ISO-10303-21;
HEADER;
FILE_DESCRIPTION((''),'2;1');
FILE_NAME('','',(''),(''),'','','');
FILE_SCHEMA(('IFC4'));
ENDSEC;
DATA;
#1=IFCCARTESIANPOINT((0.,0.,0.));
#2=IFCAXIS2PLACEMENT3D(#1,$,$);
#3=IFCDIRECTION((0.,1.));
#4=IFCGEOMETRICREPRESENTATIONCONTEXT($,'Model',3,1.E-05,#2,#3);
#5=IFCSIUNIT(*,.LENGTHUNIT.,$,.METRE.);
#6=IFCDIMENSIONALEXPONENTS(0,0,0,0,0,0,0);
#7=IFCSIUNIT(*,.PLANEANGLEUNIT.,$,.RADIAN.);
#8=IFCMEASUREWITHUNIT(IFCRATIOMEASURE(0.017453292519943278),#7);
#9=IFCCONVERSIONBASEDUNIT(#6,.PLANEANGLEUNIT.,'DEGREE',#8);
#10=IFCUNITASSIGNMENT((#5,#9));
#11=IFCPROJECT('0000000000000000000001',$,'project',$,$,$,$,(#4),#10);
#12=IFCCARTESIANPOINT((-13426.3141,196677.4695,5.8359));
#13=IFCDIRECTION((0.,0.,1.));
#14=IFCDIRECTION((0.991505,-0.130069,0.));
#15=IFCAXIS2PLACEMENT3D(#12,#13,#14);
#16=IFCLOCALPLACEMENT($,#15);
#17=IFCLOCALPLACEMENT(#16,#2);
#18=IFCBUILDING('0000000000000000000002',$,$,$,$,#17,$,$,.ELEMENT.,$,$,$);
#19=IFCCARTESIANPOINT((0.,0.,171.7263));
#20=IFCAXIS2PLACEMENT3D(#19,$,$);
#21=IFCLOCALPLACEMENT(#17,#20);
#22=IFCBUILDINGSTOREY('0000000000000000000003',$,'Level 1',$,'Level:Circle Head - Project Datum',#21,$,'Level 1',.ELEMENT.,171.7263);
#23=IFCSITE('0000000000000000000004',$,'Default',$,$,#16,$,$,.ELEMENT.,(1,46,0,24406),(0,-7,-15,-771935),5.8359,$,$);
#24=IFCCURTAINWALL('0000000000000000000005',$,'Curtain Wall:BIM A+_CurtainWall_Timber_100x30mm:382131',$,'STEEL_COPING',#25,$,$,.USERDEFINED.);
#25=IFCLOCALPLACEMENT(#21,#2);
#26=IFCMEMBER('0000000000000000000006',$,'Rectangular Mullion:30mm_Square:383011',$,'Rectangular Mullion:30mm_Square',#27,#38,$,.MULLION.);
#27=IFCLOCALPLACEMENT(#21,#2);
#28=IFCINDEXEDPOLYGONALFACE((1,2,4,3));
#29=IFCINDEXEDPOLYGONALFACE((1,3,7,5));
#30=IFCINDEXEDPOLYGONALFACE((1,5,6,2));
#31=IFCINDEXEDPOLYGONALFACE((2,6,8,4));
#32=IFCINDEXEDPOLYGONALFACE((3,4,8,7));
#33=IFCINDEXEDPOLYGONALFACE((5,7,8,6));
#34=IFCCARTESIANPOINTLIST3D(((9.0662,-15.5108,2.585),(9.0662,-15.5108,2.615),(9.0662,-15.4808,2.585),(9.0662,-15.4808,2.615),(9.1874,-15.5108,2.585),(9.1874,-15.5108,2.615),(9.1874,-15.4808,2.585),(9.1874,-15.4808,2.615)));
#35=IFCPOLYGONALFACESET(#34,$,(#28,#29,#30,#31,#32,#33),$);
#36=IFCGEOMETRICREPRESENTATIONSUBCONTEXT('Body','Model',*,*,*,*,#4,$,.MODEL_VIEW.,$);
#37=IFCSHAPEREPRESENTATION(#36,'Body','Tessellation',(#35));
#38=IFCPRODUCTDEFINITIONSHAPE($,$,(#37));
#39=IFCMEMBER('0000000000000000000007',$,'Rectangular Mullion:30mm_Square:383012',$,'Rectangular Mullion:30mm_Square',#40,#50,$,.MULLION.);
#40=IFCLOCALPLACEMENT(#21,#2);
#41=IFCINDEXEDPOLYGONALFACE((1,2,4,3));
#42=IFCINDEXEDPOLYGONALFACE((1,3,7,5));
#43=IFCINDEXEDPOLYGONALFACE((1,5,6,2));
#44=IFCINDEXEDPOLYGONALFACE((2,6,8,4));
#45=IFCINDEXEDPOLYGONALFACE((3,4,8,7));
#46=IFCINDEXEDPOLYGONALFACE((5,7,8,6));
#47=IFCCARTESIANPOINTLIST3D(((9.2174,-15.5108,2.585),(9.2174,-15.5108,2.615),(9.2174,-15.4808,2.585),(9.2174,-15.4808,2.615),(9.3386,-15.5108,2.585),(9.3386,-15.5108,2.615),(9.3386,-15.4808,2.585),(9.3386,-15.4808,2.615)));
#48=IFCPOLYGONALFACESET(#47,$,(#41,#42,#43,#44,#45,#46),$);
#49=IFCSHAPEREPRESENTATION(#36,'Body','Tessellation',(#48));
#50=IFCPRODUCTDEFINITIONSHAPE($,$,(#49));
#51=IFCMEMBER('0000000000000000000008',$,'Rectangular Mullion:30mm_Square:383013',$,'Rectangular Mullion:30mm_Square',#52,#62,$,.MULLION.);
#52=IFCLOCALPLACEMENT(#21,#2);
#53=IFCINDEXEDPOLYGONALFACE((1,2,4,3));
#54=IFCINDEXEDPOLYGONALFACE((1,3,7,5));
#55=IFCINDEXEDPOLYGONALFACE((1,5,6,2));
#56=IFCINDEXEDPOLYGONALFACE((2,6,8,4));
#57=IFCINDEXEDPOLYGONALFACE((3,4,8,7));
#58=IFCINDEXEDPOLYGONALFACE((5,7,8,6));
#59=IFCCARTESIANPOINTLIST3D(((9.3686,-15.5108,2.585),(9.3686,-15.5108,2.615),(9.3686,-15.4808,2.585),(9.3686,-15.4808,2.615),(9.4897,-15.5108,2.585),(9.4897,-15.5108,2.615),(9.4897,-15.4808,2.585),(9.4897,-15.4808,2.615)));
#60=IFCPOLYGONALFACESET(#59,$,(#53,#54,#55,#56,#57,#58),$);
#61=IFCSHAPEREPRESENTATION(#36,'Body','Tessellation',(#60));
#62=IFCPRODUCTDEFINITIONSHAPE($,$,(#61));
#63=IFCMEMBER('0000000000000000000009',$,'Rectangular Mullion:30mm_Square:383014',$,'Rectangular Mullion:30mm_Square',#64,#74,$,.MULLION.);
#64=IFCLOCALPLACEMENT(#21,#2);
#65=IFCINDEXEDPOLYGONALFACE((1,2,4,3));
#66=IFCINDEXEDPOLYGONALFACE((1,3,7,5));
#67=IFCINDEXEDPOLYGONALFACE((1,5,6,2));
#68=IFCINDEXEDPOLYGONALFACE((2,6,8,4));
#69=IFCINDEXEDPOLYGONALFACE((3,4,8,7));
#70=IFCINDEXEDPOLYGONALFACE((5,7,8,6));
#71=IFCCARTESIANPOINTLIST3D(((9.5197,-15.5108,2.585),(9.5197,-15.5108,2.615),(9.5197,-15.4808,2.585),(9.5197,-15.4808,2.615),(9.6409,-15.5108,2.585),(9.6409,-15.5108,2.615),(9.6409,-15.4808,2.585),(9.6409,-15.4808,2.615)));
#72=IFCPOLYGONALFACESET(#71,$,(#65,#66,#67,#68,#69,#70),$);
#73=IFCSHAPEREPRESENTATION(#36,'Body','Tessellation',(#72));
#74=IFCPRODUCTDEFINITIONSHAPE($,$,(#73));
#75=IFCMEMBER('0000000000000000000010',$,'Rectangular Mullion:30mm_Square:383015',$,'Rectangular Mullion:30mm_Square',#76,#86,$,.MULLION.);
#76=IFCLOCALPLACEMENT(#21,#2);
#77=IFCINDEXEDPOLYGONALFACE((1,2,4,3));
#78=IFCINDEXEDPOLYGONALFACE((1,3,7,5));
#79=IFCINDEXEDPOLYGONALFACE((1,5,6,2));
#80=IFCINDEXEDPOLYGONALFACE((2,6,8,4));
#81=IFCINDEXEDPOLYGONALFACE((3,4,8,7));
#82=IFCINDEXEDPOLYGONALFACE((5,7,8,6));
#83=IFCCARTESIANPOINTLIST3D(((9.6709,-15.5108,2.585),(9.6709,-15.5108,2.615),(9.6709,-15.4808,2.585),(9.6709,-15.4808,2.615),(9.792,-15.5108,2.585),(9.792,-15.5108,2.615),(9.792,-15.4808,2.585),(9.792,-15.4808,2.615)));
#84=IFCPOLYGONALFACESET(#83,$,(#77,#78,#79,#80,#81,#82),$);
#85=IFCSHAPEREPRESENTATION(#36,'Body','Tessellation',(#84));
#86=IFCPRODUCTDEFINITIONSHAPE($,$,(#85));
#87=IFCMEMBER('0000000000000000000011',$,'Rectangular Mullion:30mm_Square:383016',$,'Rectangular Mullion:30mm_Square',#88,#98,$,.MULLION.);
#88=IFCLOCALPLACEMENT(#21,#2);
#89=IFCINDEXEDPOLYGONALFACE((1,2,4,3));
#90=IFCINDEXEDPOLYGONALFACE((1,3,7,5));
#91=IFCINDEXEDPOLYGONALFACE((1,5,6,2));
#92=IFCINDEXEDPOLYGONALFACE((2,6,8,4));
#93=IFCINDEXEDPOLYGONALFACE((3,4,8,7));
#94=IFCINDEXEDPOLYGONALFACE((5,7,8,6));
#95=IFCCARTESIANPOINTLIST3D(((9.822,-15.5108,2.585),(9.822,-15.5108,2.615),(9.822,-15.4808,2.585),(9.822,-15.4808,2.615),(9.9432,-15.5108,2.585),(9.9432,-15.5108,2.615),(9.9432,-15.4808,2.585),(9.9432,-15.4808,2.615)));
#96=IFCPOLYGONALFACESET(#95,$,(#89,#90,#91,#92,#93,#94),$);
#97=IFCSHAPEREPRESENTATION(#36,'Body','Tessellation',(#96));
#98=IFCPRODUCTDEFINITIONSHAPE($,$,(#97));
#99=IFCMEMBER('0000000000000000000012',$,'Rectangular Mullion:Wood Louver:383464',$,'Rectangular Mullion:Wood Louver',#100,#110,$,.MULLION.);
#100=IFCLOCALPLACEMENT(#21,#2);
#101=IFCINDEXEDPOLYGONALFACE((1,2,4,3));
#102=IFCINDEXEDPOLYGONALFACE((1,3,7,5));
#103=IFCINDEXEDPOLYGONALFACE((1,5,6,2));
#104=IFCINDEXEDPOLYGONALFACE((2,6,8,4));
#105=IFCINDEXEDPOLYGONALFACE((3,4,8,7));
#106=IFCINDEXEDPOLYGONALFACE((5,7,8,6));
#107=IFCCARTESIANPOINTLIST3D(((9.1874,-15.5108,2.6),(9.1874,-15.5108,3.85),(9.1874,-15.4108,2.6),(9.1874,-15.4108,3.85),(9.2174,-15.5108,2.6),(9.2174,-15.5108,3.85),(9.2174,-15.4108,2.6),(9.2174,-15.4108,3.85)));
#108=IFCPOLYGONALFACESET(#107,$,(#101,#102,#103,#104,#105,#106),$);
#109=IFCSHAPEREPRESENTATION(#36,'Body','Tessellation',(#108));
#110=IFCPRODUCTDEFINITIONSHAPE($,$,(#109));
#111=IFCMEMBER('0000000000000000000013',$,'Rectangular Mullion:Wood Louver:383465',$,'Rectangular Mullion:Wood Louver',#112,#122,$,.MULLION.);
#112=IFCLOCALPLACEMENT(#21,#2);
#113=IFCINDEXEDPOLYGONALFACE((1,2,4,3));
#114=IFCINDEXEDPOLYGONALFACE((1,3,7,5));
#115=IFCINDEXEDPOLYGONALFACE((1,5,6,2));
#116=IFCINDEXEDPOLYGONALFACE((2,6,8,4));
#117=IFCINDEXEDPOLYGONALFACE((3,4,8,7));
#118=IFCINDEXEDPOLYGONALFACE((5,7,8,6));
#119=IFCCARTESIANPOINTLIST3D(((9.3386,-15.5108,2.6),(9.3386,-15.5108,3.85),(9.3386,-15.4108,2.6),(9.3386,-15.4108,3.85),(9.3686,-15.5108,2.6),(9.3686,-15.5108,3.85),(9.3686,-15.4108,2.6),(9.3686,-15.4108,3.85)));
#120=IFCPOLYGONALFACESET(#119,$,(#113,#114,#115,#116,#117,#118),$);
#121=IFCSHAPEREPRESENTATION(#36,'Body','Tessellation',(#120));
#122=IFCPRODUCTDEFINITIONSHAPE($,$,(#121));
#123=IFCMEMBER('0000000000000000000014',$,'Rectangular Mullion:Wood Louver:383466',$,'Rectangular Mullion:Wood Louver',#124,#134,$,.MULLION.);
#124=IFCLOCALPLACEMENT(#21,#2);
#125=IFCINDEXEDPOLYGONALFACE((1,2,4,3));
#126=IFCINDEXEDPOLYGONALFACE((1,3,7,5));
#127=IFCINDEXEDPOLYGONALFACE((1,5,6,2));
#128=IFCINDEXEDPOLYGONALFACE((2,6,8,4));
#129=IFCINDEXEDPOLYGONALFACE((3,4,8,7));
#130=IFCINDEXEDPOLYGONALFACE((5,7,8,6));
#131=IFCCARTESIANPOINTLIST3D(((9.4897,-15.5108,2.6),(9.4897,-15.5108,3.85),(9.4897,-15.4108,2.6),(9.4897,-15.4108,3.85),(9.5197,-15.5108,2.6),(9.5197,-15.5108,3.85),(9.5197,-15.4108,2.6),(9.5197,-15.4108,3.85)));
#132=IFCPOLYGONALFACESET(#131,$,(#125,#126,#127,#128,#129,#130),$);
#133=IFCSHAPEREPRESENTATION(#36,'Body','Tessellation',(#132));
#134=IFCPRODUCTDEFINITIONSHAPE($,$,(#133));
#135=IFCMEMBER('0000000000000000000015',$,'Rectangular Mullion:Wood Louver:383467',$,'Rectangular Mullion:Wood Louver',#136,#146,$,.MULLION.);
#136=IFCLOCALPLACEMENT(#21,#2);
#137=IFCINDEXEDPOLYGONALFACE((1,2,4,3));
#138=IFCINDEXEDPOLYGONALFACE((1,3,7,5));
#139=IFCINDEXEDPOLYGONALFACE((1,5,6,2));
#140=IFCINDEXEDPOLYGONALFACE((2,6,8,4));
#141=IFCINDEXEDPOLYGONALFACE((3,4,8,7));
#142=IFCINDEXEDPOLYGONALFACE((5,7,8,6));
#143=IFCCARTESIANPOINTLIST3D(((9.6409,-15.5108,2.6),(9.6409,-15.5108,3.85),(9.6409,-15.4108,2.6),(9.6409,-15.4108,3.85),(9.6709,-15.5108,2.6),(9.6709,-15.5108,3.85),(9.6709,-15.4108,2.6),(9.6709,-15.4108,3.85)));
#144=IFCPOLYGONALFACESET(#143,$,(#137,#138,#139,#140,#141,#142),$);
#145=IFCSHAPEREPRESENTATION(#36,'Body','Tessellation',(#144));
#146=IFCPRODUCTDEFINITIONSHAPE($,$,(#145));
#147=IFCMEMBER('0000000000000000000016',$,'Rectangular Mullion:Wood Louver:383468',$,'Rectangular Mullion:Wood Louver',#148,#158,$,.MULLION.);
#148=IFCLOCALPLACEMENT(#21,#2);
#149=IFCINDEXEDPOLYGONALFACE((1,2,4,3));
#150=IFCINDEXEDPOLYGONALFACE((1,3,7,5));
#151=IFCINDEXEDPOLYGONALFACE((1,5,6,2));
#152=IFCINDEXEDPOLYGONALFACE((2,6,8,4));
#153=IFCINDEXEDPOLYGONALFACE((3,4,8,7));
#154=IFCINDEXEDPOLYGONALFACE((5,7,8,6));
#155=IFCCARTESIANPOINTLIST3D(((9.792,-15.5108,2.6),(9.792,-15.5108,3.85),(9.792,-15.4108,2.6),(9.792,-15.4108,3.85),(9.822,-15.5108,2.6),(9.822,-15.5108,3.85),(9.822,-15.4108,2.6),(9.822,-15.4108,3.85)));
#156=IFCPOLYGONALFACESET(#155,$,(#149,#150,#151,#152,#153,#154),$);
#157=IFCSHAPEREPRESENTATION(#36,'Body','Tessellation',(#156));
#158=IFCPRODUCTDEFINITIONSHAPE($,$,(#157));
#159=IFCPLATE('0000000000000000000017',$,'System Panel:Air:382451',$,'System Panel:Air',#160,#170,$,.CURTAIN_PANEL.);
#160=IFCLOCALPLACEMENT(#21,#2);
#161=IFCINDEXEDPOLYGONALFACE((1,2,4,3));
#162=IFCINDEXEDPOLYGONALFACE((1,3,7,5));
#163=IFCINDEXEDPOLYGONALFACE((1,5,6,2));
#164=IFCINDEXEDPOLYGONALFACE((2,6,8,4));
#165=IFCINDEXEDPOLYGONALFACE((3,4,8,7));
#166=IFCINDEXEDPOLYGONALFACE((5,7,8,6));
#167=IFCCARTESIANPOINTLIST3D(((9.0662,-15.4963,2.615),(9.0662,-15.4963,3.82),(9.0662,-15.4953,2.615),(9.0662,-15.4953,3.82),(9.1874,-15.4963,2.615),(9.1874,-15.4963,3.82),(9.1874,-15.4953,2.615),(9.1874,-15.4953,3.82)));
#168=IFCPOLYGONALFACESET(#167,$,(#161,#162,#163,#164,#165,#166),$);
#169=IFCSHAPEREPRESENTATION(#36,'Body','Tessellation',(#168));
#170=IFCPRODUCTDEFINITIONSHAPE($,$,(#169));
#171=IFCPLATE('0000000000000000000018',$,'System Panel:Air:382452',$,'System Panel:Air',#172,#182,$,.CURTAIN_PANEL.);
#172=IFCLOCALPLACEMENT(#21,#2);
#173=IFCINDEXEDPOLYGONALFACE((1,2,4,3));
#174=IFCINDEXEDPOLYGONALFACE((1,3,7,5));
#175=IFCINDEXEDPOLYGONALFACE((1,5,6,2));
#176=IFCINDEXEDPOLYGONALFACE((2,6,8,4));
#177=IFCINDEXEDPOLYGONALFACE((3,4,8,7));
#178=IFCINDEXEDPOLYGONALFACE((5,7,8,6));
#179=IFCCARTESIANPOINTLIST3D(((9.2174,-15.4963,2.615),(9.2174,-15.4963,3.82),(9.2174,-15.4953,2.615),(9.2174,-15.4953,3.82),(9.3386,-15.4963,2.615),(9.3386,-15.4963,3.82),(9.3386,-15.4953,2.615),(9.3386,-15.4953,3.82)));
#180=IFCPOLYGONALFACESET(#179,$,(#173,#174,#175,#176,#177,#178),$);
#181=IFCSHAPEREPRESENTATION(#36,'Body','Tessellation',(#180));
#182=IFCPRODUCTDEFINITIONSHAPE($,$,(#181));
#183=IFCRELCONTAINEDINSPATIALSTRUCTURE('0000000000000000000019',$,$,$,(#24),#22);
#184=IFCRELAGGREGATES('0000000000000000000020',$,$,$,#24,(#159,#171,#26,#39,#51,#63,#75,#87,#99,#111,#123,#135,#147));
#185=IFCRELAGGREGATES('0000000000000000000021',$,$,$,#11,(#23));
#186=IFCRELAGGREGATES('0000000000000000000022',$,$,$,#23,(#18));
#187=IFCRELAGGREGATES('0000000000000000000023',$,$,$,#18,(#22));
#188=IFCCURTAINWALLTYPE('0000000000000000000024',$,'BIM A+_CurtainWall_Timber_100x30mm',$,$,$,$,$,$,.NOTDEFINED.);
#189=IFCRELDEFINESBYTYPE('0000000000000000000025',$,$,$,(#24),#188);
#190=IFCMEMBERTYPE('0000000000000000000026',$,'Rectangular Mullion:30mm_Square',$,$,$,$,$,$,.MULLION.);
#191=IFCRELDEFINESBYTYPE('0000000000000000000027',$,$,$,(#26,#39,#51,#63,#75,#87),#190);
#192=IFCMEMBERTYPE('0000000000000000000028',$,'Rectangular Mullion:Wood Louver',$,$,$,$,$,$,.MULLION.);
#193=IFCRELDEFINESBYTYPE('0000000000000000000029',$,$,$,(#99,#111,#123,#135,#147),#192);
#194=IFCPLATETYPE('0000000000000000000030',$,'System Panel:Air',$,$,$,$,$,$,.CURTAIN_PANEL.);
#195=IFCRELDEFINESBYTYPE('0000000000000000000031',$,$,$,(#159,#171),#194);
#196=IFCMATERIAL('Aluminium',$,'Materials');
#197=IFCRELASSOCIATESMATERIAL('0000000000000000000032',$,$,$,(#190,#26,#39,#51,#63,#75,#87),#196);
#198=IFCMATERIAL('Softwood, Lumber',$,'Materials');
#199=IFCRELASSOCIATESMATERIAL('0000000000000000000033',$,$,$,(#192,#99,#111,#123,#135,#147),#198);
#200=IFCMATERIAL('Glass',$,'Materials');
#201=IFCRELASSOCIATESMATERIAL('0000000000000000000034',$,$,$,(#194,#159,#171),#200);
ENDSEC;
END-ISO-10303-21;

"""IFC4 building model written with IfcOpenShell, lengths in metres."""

from ifc_helpers import new_model, entity, si_unit, converted_unit, direction, frame, origin, place, context, subcontext, project, spatial, indexed_curve, outline, extrude, source, transform, mapped, material, type_object, type_shapes, element, aggregate, save


model = new_model("IFC4")

# Units and contexts
model_context = context("Model", 3, precision=1e-05, world=origin(), true_north=direction((0.0, 1.0)))
body_context = subcontext(model_context, "Body", "Model", "MODEL_VIEW")
ifc_project = project(units=[si_unit("LENGTHUNIT", "METRE"), converted_unit("PLANEANGLEUNIT", "DEGREE", entity("IfcRatioMeasure", 0.017453292519943278), si_unit("PLANEANGLEUNIT", "RADIAN"), dimensions=[0, 0, 0, 0, 0, 0, 0])], contexts=[model_context])

# Site, building, storey
site_placement = place(None, frame((-13426.3141, 196677.4695, 5.8359), z_axis=(0.0, 0.0, 1.0), x_axis=(0.991505, -0.130069, 0.0)))
site = spatial("IfcSite", under=ifc_project, at=site_placement, Name="Default", CompositionType="ELEMENT", RefLatitude=(1, 46, 0, 24406), RefLongitude=(0, -7, -15, -771935), RefElevation=5.8359)
building_placement = place(site_placement, origin())
building = spatial("IfcBuilding", under=site, at=building_placement, CompositionType="ELEMENT")
storey_placement = place(building_placement, frame((0.0, 0.0, 171.7263)))
storey = spatial("IfcBuildingStorey", under=building, at=storey_placement, Name="Level 1", ObjectType="Level:Circle Head - Project Datum", LongName="Level 1", CompositionType="ELEMENT", Elevation=171.7263)

# Curtain wall, members, plates
curtain_wall_type = type_object("IfcCurtainWallType", Name="BIM A+_CurtainWall_Timber_100x30mm", PredefinedType="NOTDEFINED")
curtain_wall_placement = place(storey_placement, frame((0.0, 0.0, -171.7263)))
curtain_wall = element("IfcCurtainWall", 1, at=curtain_wall_placement, inside=storey, type_object=curtain_wall_type, Name="Curtain Wall:BIM A+_CurtainWall_Timber_100x30mm:382131", ObjectType="STEEL_COPING", PredefinedType="USERDEFINED")
ifc_material_1 = material(Name="Aluminium", Category="Materials")
member_type_1 = type_object("IfcMemberType", Name="Rectangular Mullion:30mm_Square", PredefinedType="MULLION", material=ifc_material_1)
shared_shape_1 = source(origin(), body_context, "Body", "SweptSolid", [
    extrude(outline(indexed_curve([(-0.015, -0.015), (0.015, -0.015), (0.015, 0.015), (-0.015, 0.015), (-0.015, -0.015)], self_intersect=False)), frame((0.0, 0.0, -0.1212), z_axis=(0.0, 0.0, 1.0), x_axis=(0.0, -1.0, 0.0)), (0.0, 0.0, 1.0), 0.1212),
])
type_shapes(member_type_1, [shared_shape_1])
member_1_placement = place(curtain_wall_placement, frame((9.1874, -15.4958, 174.3263), z_axis=(1.0, 0.0, 0.0), x_axis=(0.0, 0.0, 1.0)))
member_1 = element("IfcMember", 2, at=member_1_placement, type_object=member_type_1, material=ifc_material_1, Name="Rectangular Mullion:30mm_Square:383011", ObjectType="Rectangular Mullion:30mm_Square", PredefinedType="MULLION", context=body_context, shape_type="MappedRepresentation", body=[
    mapped(shared_shape_1, transform((0.0, 0.0, 0.0), scale=1.0)),
])
member_2_placement = place(curtain_wall_placement, frame((9.3386, -15.4958, 174.3263), z_axis=(1.0, 0.0, 0.0), x_axis=(0.0, 0.0, 1.0)))
member_2 = element("IfcMember", 3, at=member_2_placement, type_object=member_type_1, material=ifc_material_1, Name="Rectangular Mullion:30mm_Square:383012", ObjectType="Rectangular Mullion:30mm_Square", PredefinedType="MULLION", context=body_context, shape_type="MappedRepresentation", body=[
    mapped(shared_shape_1, transform((0.0, 0.0, 0.0), scale=1.0)),
])
member_3_placement = place(curtain_wall_placement, frame((9.4897, -15.4958, 174.3263), z_axis=(1.0, 0.0, 0.0), x_axis=(0.0, 0.0, 1.0)))
member_3 = element("IfcMember", 4, at=member_3_placement, type_object=member_type_1, material=ifc_material_1, Name="Rectangular Mullion:30mm_Square:383013", ObjectType="Rectangular Mullion:30mm_Square", PredefinedType="MULLION", context=body_context, shape_type="MappedRepresentation", body=[
    mapped(shared_shape_1, transform((0.0, 0.0, 0.0), scale=1.0)),
])
member_4_placement = place(curtain_wall_placement, frame((9.6409, -15.4958, 174.3263), z_axis=(1.0, 0.0, 0.0), x_axis=(0.0, 0.0, 1.0)))
member_4 = element("IfcMember", 5, at=member_4_placement, type_object=member_type_1, material=ifc_material_1, Name="Rectangular Mullion:30mm_Square:383014", ObjectType="Rectangular Mullion:30mm_Square", PredefinedType="MULLION", context=body_context, shape_type="MappedRepresentation", body=[
    mapped(shared_shape_1, transform((0.0, 0.0, 0.0), scale=1.0)),
])
member_5_placement = place(curtain_wall_placement, frame((9.792, -15.4958, 174.3263), z_axis=(1.0, 0.0, 0.0), x_axis=(0.0, 0.0, 1.0)))
member_5 = element("IfcMember", 6, at=member_5_placement, type_object=member_type_1, material=ifc_material_1, Name="Rectangular Mullion:30mm_Square:383015", ObjectType="Rectangular Mullion:30mm_Square", PredefinedType="MULLION", context=body_context, shape_type="MappedRepresentation", body=[
    mapped(shared_shape_1, transform((0.0, 0.0, 0.0), scale=1.0)),
])
member_6_placement = place(curtain_wall_placement, frame((9.9432, -15.4958, 174.3263), z_axis=(1.0, 0.0, 0.0), x_axis=(0.0, 0.0, 1.0)))
member_6 = element("IfcMember", 7, at=member_6_placement, type_object=member_type_1, material=ifc_material_1, Name="Rectangular Mullion:30mm_Square:383016", ObjectType="Rectangular Mullion:30mm_Square", PredefinedType="MULLION", context=body_context, shape_type="MappedRepresentation", body=[
    mapped(shared_shape_1, transform((0.0, 0.0, 0.0), scale=1.0)),
])
ifc_material_2 = material(Name="Softwood, Lumber", Category="Materials")
member_type_2 = type_object("IfcMemberType", Name="Rectangular Mullion:Wood Louver", PredefinedType="MULLION", material=ifc_material_2)
shared_shape_2 = source(origin(), body_context, "Body", "SweptSolid", [
    extrude(outline(indexed_curve([(-0.05, -0.015), (0.05, -0.015), (0.05, 0.015), (-0.05, 0.015), (-0.05, -0.015)], self_intersect=False)), frame((0.0, -0.035, -1.25), z_axis=(0.0, 0.0, 1.0), x_axis=(0.0, -1.0, 0.0)), (0.0, 0.0, 1.0), 1.25),
])
type_shapes(member_type_2, [shared_shape_2])
member_7_placement = place(curtain_wall_placement, frame((9.2024, -15.4958, 174.3263), z_axis=(0.0, 0.0, -1.0), x_axis=(1.0, 0.0, 0.0)))
member_7 = element("IfcMember", 8, at=member_7_placement, type_object=member_type_2, material=ifc_material_2, Name="Rectangular Mullion:Wood Louver:383464", ObjectType="Rectangular Mullion:Wood Louver", PredefinedType="MULLION", context=body_context, shape_type="MappedRepresentation", body=[
    mapped(shared_shape_2, transform((0.0, 0.0, 0.0), scale=1.0)),
])
member_8_placement = place(curtain_wall_placement, frame((9.3536, -15.4958, 174.3263), z_axis=(0.0, 0.0, -1.0), x_axis=(1.0, 0.0, 0.0)))
member_8 = element("IfcMember", 9, at=member_8_placement, type_object=member_type_2, material=ifc_material_2, Name="Rectangular Mullion:Wood Louver:383465", ObjectType="Rectangular Mullion:Wood Louver", PredefinedType="MULLION", context=body_context, shape_type="MappedRepresentation", body=[
    mapped(shared_shape_2, transform((0.0, 0.0, 0.0), scale=1.0)),
])
member_9_placement = place(curtain_wall_placement, frame((9.5047, -15.4958, 174.3263), z_axis=(0.0, 0.0, -1.0), x_axis=(1.0, 0.0, 0.0)))
member_9 = element("IfcMember", 10, at=member_9_placement, type_object=member_type_2, material=ifc_material_2, Name="Rectangular Mullion:Wood Louver:383466", ObjectType="Rectangular Mullion:Wood Louver", PredefinedType="MULLION", context=body_context, shape_type="MappedRepresentation", body=[
    mapped(shared_shape_2, transform((0.0, 0.0, 0.0), scale=1.0)),
])
member_10_placement = place(curtain_wall_placement, frame((9.6559, -15.4958, 174.3263), z_axis=(0.0, 0.0, -1.0), x_axis=(1.0, 0.0, 0.0)))
member_10 = element("IfcMember", 11, at=member_10_placement, type_object=member_type_2, material=ifc_material_2, Name="Rectangular Mullion:Wood Louver:383467", ObjectType="Rectangular Mullion:Wood Louver", PredefinedType="MULLION", context=body_context, shape_type="MappedRepresentation", body=[
    mapped(shared_shape_2, transform((0.0, 0.0, 0.0), scale=1.0)),
])
member_11_placement = place(curtain_wall_placement, frame((9.807, -15.4958, 174.3263), z_axis=(0.0, 0.0, -1.0), x_axis=(1.0, 0.0, 0.0)))
member_11 = element("IfcMember", 12, at=member_11_placement, type_object=member_type_2, material=ifc_material_2, Name="Rectangular Mullion:Wood Louver:383468", ObjectType="Rectangular Mullion:Wood Louver", PredefinedType="MULLION", context=body_context, shape_type="MappedRepresentation", body=[
    mapped(shared_shape_2, transform((0.0, 0.0, 0.0), scale=1.0)),
])
ifc_material_3 = material(Name="Glass", Category="Materials")
plate_type = type_object("IfcPlateType", Name="System Panel:Air", PredefinedType="CURTAIN_PANEL", material=ifc_material_3)
shared_shape_3 = source(origin(), body_context, "Body", "SweptSolid", [
    extrude(outline(indexed_curve([(-0.0005, -0.0606), (0.0005, -0.0606), (0.0005, 0.0606), (-0.0005, 0.0606), (-0.0005, -0.0606)], self_intersect=False)), frame((0.0, 0.0, 0.0), z_axis=(0.0, 0.0, 1.0), x_axis=(0.0, 1.0, 0.0)), (0.0, 0.0, 1.0), 1.205),
])
type_shapes(plate_type, [shared_shape_3])
plate_1_placement = place(curtain_wall_placement, frame((9.1268, -15.4958, 174.3413)))
plate_1 = element("IfcPlate", 13, at=plate_1_placement, type_object=plate_type, material=ifc_material_3, Name="System Panel:Air:382451", ObjectType="System Panel:Air", PredefinedType="CURTAIN_PANEL", context=body_context, shape_type="MappedRepresentation", body=[
    mapped(shared_shape_3, transform((0.0, 0.0, 0.0), scale=1.0)),
])
plate_2_placement = place(curtain_wall_placement, frame((9.278, -15.4958, 174.3413)))
plate_2 = element("IfcPlate", 14, at=plate_2_placement, type_object=plate_type, material=ifc_material_3, Name="System Panel:Air:382452", ObjectType="System Panel:Air", PredefinedType="CURTAIN_PANEL", context=body_context, shape_type="MappedRepresentation", body=[
    mapped(shared_shape_3, transform((0.0, 0.0, 0.0), scale=1.0)),
])
aggregate(curtain_wall, [plate_1, plate_2, member_1, member_2, member_3, member_4, member_5, member_6, member_7, member_8, member_9, member_10, member_11])

save(model, "model.ifc")
